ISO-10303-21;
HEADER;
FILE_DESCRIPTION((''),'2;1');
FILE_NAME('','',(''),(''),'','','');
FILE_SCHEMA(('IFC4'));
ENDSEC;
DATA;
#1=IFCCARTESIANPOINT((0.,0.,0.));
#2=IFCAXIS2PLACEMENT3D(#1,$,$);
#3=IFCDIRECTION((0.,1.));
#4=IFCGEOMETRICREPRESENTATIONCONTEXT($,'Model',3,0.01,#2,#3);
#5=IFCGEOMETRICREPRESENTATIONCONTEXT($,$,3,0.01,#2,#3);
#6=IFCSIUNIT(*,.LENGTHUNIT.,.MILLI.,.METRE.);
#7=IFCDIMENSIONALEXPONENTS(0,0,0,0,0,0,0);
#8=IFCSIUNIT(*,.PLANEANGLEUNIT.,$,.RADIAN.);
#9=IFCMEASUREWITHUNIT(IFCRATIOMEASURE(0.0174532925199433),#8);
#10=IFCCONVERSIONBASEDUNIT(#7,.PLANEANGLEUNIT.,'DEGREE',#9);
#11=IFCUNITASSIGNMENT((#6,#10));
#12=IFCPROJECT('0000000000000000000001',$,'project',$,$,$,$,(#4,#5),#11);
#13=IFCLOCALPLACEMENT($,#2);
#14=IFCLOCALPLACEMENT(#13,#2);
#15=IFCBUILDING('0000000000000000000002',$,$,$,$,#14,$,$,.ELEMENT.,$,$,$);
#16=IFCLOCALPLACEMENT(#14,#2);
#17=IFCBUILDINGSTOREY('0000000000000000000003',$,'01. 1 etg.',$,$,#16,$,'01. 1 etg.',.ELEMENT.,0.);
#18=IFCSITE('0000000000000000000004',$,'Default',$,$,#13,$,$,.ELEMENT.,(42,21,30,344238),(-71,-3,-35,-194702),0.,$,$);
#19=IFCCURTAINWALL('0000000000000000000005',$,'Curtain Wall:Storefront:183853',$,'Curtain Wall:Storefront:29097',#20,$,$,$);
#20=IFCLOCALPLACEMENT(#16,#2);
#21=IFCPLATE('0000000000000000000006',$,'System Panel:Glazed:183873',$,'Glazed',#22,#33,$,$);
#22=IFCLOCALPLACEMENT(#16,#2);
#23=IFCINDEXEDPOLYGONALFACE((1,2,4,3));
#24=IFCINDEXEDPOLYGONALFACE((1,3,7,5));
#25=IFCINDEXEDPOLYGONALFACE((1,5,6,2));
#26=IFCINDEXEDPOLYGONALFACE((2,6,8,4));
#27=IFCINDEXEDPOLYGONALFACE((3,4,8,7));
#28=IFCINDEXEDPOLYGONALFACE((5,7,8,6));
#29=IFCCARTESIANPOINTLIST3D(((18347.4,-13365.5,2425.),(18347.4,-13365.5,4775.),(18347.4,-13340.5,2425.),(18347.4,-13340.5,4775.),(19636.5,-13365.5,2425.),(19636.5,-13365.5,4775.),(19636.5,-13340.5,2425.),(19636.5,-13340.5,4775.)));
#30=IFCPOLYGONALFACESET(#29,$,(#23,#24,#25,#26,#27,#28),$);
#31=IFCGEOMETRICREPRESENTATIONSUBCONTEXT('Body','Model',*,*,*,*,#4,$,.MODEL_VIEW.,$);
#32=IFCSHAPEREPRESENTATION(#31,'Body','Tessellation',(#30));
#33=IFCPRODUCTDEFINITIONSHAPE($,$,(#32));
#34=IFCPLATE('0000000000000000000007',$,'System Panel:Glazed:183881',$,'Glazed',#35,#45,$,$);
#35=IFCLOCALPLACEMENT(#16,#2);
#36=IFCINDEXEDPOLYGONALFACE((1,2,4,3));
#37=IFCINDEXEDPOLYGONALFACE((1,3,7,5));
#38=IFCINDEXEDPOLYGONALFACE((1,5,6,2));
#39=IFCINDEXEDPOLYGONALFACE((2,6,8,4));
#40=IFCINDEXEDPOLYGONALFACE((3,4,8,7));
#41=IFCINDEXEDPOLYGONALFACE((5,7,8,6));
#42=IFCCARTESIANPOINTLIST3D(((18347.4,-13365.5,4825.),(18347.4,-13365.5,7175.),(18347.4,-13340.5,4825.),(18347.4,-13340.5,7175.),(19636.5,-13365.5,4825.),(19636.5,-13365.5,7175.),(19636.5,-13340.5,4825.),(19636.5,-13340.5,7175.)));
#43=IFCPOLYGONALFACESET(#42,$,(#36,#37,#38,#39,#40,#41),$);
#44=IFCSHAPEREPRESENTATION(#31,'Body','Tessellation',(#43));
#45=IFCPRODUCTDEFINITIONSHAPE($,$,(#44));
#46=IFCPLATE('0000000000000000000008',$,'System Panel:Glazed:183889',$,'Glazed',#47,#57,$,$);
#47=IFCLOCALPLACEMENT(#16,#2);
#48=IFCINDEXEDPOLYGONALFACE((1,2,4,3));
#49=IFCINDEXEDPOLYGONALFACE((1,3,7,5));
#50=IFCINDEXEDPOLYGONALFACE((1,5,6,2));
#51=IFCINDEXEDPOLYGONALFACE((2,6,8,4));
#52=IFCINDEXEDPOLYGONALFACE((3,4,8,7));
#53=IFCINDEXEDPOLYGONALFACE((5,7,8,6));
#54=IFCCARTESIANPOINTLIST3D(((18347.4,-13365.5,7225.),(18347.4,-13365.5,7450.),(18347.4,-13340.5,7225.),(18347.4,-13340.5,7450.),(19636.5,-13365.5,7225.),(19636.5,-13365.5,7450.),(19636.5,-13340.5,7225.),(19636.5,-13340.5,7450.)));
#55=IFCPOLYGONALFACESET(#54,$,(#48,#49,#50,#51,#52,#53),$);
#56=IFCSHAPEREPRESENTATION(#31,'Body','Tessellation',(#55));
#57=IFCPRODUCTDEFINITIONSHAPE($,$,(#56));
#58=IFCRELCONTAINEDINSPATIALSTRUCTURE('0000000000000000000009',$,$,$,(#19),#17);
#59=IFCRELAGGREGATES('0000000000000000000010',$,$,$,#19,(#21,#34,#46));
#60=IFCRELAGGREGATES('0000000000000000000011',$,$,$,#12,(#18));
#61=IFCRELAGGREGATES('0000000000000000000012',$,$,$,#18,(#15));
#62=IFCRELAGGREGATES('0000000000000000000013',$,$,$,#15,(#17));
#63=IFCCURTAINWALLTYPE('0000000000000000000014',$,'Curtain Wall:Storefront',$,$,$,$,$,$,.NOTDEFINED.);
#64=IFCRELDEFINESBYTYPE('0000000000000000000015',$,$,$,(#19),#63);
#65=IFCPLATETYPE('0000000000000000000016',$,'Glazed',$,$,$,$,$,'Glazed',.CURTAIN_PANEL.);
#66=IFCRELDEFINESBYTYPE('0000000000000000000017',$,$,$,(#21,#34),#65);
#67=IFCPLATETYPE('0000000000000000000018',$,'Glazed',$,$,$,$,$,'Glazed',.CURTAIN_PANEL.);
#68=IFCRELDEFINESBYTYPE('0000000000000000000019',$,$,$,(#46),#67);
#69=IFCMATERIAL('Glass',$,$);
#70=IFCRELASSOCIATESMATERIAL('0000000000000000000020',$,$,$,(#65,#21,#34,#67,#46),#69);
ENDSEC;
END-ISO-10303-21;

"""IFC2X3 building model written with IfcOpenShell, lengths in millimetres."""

from ifc_helpers import new_model, entity, si_unit, converted_unit, direction, frame, origin, origin_2d_with_axis, place, context, subcontext, project, spatial, rectangle, extrude, source, transform, mapped, material, type_object, type_shapes, element, aggregate, save


model = new_model("IFC2X3")

# Units and contexts
model_context = context("Model", 3, precision=0.01, world=origin(), true_north=direction((0.0, 1.0)))
context_of_model = context(None, 3, precision=0.01, world=origin(), true_north=direction((0.0, 1.0)))
body_context = subcontext(model_context, "Body", "Model", "MODEL_VIEW")
ifc_project = project(units=[si_unit("LENGTHUNIT", "METRE", prefix="MILLI"), converted_unit("PLANEANGLEUNIT", "DEGREE", entity("IfcRatioMeasure", 0.0174532925199433), si_unit("PLANEANGLEUNIT", "RADIAN"), dimensions=[0, 0, 0, 0, 0, 0, 0])], contexts=[model_context, context_of_model])

# Site, building, storey
site_placement = place(None, origin())
site = spatial("IfcSite", under=ifc_project, at=site_placement, Name="Default", CompositionType="ELEMENT", RefLatitude=(42, 21, 30, 344238), RefLongitude=(-71, -3, -35, -194702), RefElevation=0.0)
building_placement = place(site_placement, origin())
building = spatial("IfcBuilding", under=site, at=building_placement, CompositionType="ELEMENT")
storey_placement = place(building_placement, origin())
storey = spatial("IfcBuildingStorey", under=building, at=storey_placement, Name="01. 1 etg.", LongName="01. 1 etg.", CompositionType="ELEMENT", Elevation=0.0)

# Curtain wall, plates
curtain_wall_type = type_object("IfcCurtainWallType", Name="Curtain Wall:Storefront", PredefinedType="NOTDEFINED")
curtain_wall_placement = place(storey_placement, origin())
curtain_wall = element("IfcCurtainWall", 1, at=curtain_wall_placement, inside=storey, type_object=curtain_wall_type, Name="Curtain Wall:Storefront:183853", ObjectType="Curtain Wall:Storefront:29097")
ifc_material_1 = material(Name="Glass")
plate_type_1 = type_object("IfcPlateType", Name="Glazed", ElementType="Glazed", PredefinedType="CURTAIN_PANEL", material=ifc_material_1)
shared_shape_1 = source(origin(), body_context, "Body", "SweptSolid", [
    extrude(rectangle(XDim=25.0, YDim=1289.2, at=origin_2d_with_axis()), frame((644.6, 12.5, 0.0), z_axis=(0.0, 0.0, 1.0), x_axis=(0.0, 1.0, 0.0)), (0.0, 0.0, 1.0), 2350.0),
])
type_shapes(plate_type_1, [shared_shape_1])
plate_1_placement = place(curtain_wall_placement, frame((18347.4, -13365.5, 2425.0)))
plate_1 = element("IfcPlate", 2, at=plate_1_placement, type_object=plate_type_1, material=ifc_material_1, Name="System Panel:Glazed:183873", ObjectType="Glazed", context=body_context, shape_type="MappedRepresentation", body=[
    mapped(shared_shape_1, transform((0.0, 0.0, 0.0), scale=1.0)),
])
plate_2_placement = place(curtain_wall_placement, frame((18347.4, -13365.5, 4825.0)))
plate_2 = element("IfcPlate", 3, at=plate_2_placement, type_object=plate_type_1, material=ifc_material_1, Name="System Panel:Glazed:183881", ObjectType="Glazed", context=body_context, shape_type="MappedRepresentation", body=[
    mapped(shared_shape_1, transform((0.0, 0.0, 0.0), scale=1.0)),
])
plate_type_2 = type_object("IfcPlateType", Name="Glazed", ElementType="Glazed", PredefinedType="CURTAIN_PANEL", material=ifc_material_1)
shared_shape_2 = source(origin(), body_context, "Body", "SweptSolid", [
    extrude(rectangle(XDim=25.0, YDim=1289.2, at=origin_2d_with_axis()), frame((644.6, 12.5, 0.0), z_axis=(0.0, 0.0, 1.0), x_axis=(0.0, 1.0, 0.0)), (0.0, 0.0, 1.0), 225.0),
])
type_shapes(plate_type_2, [shared_shape_2])
plate_3_placement = place(curtain_wall_placement, frame((18347.4, -13365.5, 7225.0)))
plate_3 = element("IfcPlate", 4, at=plate_3_placement, type_object=plate_type_2, material=ifc_material_1, Name="System Panel:Glazed:183889", ObjectType="Glazed", context=body_context, shape_type="MappedRepresentation", body=[
    mapped(shared_shape_2, transform((0.0, 0.0, 0.0), scale=1.0)),
])
aggregate(curtain_wall, [plate_1, plate_2, plate_3])

save(model, "model.ifc")
